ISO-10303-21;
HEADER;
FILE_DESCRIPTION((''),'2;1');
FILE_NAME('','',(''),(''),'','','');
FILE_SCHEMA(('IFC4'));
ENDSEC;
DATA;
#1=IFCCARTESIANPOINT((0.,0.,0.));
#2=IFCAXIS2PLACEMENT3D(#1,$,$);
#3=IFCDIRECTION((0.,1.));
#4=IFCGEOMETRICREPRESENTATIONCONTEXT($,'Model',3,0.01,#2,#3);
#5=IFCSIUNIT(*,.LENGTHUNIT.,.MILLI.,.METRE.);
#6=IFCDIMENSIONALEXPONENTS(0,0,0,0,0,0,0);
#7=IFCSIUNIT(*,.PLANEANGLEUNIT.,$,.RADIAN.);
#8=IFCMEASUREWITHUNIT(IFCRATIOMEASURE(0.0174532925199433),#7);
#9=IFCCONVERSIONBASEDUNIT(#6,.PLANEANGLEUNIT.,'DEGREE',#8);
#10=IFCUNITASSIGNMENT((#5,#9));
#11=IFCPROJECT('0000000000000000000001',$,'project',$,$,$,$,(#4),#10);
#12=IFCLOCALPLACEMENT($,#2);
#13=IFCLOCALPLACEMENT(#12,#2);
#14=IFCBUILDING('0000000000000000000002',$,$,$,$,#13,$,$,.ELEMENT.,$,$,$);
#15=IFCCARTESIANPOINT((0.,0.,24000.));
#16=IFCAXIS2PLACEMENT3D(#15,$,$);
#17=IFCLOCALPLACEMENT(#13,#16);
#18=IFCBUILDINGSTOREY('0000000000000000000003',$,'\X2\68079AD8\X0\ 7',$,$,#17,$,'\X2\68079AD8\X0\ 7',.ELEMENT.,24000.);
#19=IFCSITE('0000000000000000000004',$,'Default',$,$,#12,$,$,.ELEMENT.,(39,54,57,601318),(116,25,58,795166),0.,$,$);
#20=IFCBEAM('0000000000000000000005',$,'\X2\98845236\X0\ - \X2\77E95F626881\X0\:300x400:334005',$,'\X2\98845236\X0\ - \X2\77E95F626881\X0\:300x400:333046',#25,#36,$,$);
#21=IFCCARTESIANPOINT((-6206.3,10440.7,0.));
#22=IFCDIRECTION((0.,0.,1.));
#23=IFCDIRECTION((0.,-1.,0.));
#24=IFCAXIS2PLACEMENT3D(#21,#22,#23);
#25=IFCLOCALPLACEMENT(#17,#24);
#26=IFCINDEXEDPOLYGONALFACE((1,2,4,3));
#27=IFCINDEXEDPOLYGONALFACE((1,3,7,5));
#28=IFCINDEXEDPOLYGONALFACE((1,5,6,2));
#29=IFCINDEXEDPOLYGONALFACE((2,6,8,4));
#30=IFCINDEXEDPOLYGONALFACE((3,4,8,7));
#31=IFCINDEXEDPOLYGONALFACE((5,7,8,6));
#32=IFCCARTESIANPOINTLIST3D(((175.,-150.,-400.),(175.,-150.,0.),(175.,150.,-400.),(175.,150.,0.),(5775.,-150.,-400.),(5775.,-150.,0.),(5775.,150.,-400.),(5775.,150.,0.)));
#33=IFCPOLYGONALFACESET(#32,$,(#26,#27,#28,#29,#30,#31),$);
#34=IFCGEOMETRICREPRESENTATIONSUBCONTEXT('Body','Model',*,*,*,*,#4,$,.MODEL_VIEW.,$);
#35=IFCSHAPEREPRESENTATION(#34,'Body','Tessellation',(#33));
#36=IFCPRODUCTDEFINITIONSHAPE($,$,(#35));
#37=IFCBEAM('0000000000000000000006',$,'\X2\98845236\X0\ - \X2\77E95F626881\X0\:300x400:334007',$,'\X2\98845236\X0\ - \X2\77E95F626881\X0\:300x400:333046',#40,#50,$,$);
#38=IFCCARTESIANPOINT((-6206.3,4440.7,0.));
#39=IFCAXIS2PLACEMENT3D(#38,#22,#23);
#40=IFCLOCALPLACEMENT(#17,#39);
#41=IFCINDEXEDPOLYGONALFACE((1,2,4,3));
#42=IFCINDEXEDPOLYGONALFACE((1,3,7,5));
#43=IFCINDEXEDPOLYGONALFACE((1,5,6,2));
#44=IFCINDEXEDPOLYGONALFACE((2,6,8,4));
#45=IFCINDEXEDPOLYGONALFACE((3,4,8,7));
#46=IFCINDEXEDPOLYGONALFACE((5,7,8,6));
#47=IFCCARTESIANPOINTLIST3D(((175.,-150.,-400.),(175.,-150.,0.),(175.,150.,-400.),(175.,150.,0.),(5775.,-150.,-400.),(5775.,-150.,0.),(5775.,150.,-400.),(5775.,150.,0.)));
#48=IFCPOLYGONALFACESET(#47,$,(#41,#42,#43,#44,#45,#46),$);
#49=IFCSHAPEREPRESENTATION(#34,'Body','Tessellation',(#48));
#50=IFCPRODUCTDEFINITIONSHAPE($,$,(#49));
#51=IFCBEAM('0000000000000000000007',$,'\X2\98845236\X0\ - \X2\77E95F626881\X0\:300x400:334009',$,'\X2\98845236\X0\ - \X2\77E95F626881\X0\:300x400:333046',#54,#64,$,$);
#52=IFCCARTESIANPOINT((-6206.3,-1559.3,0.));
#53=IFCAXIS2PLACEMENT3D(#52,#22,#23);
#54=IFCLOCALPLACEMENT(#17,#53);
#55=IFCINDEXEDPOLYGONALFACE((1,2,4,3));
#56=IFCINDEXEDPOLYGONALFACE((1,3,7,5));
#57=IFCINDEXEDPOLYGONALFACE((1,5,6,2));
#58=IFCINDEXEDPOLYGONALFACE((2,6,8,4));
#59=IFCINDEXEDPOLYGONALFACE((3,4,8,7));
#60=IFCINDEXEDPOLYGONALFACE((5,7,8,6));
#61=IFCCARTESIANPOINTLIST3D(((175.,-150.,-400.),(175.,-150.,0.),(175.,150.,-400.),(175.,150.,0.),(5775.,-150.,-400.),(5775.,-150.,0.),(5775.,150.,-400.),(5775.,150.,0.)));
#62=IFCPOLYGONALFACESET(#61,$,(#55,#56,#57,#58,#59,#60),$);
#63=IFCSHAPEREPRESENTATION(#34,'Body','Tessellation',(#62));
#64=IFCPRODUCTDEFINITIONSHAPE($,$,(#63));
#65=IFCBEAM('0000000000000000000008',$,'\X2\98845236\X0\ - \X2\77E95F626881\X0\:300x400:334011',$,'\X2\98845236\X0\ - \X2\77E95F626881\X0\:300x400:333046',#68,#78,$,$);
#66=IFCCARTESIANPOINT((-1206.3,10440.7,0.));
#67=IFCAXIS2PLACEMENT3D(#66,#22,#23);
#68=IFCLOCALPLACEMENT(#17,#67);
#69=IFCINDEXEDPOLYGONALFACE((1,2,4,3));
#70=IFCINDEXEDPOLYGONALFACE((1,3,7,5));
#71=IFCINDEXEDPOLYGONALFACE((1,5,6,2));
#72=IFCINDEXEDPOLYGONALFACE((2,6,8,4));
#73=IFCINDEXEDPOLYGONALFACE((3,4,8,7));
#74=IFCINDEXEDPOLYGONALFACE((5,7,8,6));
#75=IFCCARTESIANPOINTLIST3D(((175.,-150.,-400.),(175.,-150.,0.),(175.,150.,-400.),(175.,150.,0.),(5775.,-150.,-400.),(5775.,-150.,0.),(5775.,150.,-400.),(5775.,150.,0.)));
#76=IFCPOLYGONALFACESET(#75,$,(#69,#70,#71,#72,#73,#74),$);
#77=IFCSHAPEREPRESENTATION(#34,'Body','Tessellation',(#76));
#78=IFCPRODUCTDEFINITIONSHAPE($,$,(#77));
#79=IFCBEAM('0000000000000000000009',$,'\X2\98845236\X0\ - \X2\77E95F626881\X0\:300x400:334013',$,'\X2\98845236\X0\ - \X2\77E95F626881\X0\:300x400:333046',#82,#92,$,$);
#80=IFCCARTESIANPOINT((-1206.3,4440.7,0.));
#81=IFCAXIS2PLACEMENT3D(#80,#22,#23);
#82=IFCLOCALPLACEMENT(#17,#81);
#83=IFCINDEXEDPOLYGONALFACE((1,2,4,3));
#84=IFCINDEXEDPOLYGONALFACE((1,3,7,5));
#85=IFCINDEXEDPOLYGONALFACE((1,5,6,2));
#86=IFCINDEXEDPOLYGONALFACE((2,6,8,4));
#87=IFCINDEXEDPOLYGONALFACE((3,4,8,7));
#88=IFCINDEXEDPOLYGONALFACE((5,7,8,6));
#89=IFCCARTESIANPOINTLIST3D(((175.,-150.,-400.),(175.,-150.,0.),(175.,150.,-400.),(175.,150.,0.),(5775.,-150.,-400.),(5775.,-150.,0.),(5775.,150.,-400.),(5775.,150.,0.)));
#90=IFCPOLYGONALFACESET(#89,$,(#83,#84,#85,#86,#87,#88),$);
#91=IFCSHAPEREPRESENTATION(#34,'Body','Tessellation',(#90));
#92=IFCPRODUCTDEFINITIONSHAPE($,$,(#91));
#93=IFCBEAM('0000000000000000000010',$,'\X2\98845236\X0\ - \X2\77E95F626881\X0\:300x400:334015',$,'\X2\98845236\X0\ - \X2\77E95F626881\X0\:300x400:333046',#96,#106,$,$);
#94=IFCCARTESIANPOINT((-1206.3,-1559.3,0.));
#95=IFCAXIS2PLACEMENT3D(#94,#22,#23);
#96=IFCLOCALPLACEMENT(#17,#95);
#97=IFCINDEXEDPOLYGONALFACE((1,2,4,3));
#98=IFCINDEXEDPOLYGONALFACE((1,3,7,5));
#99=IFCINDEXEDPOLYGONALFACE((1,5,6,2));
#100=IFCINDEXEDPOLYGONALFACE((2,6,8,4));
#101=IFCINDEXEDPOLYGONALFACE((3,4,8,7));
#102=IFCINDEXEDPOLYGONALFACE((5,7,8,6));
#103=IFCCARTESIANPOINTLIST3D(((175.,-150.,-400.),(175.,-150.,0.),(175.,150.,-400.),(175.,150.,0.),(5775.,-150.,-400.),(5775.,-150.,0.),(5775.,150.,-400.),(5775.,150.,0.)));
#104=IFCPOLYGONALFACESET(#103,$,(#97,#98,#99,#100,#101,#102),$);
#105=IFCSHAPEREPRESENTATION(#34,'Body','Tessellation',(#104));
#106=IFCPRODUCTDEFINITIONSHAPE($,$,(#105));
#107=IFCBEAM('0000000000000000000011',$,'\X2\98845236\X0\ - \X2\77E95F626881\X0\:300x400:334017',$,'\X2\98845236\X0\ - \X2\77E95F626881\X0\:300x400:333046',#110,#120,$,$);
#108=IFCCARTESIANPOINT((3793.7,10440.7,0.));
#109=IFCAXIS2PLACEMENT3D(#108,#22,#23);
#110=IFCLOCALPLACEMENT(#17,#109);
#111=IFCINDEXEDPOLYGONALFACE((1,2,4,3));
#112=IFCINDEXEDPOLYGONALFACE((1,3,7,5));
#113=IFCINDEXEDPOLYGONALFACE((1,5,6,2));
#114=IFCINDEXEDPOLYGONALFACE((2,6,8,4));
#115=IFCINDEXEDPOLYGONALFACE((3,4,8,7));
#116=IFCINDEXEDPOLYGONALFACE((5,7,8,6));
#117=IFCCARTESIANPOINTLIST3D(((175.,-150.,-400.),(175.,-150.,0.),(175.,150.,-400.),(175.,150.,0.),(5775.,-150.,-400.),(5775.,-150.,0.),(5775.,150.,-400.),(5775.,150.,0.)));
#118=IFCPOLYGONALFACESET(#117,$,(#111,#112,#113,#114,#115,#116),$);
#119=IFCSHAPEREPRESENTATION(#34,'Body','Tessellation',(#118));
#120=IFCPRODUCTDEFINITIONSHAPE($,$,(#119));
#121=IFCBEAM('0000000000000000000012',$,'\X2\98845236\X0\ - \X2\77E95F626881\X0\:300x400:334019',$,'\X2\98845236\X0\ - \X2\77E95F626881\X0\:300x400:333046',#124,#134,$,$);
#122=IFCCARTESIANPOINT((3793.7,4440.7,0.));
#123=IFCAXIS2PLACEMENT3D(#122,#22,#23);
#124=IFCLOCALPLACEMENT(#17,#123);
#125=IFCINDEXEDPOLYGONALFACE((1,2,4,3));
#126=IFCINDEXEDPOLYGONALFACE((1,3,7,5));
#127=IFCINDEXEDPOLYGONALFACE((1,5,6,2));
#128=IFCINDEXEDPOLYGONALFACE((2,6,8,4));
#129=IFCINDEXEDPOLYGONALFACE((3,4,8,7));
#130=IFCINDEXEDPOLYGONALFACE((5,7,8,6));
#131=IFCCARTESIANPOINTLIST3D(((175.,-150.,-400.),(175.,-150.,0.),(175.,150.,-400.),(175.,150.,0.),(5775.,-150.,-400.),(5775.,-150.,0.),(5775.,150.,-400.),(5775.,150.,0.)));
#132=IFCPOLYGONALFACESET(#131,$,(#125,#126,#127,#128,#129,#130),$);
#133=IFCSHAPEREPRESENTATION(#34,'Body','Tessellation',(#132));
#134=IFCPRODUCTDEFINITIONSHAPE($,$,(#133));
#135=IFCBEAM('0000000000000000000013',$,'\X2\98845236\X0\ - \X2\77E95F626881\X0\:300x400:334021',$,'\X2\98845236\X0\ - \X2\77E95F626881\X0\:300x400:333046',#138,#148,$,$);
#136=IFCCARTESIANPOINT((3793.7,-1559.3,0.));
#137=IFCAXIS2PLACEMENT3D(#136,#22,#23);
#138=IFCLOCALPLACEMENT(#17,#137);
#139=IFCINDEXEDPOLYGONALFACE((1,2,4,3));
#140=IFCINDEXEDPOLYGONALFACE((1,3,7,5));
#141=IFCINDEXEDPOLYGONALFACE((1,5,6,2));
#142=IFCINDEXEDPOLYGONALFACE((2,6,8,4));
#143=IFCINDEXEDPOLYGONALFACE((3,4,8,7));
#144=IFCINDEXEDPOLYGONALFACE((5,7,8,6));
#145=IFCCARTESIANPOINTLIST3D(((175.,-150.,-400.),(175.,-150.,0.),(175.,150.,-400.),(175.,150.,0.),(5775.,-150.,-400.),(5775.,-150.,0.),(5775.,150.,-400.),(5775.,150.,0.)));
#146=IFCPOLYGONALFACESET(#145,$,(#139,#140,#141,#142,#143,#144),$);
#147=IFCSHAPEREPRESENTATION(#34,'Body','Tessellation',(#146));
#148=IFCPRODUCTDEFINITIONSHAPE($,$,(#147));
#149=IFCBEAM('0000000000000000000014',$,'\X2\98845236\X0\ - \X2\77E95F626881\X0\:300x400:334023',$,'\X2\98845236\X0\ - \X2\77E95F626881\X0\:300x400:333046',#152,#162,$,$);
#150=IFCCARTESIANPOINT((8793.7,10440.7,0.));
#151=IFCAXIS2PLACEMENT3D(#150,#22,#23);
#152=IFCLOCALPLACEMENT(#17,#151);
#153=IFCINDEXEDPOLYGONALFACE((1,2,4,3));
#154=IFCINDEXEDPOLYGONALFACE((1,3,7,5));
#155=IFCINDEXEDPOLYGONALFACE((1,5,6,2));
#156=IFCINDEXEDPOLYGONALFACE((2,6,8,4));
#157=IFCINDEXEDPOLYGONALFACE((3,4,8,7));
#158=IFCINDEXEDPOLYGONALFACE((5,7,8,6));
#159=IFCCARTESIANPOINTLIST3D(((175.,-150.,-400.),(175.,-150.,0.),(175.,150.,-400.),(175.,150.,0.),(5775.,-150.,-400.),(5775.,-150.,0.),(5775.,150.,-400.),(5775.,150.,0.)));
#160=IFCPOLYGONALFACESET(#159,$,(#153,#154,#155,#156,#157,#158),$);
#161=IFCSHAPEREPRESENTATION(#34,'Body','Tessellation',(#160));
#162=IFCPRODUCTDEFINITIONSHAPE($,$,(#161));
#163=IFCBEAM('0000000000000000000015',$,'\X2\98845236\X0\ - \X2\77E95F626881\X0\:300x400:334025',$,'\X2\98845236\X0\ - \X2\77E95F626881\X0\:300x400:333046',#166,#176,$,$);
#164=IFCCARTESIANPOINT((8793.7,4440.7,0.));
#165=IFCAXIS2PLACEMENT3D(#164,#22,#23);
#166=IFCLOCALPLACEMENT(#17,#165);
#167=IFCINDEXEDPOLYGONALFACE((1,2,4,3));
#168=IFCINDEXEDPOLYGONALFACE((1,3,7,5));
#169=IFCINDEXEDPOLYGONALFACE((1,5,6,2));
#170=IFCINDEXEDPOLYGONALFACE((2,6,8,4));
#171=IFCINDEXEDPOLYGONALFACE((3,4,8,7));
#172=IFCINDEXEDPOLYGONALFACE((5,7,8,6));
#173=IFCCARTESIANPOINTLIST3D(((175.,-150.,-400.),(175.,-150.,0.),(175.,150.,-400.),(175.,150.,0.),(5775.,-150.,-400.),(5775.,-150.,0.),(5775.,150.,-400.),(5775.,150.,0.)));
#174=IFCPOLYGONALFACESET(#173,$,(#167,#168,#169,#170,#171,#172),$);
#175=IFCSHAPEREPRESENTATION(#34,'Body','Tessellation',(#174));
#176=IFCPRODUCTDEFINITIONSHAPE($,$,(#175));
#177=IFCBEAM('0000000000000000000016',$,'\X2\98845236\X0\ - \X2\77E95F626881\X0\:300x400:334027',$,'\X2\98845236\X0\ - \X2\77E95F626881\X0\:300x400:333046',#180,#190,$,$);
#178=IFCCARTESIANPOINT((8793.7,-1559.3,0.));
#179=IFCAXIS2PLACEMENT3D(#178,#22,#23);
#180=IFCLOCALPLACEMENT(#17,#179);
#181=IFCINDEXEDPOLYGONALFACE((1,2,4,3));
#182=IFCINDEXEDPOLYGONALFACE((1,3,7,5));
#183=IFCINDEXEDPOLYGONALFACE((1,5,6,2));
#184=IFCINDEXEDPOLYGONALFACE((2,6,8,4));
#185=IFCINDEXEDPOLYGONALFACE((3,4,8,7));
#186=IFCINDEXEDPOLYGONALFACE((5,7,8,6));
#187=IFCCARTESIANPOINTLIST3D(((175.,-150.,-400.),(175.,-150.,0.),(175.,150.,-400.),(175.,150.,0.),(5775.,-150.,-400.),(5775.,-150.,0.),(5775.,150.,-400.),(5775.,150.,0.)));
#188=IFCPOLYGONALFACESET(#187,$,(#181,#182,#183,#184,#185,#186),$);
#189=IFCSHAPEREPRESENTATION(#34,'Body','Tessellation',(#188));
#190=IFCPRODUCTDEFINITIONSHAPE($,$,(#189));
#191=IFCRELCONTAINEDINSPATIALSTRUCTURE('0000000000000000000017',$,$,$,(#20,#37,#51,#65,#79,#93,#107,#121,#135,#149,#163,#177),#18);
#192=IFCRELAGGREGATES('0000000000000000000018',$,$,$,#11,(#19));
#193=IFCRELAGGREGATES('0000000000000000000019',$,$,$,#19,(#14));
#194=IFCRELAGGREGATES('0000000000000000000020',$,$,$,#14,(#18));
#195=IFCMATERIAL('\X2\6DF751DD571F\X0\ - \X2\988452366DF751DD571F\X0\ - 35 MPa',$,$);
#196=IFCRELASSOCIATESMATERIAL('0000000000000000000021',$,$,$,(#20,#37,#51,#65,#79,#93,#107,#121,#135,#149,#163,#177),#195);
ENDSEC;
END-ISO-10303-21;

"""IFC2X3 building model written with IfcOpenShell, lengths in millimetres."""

from ifc_helpers import new_model, entity, si_unit, converted_unit, direction, frame, frame_2d, origin, origin_2d_with_axis, place, context, subcontext, project, spatial, rectangle, extrude, material, element, save


model = new_model("IFC2X3")

# Units and contexts
model_context = context("Model", 3, precision=0.01, world=origin(), true_north=direction((0.0, 1.0)))
body_context = subcontext(model_context, "Body", "Model", "MODEL_VIEW")
ifc_project = project(units=[si_unit("LENGTHUNIT", "METRE", prefix="MILLI"), converted_unit("PLANEANGLEUNIT", "DEGREE", entity("IfcRatioMeasure", 0.0174532925199433), si_unit("PLANEANGLEUNIT", "RADIAN"), dimensions=[0, 0, 0, 0, 0, 0, 0])], contexts=[model_context])

# Site, building, storey
site_placement = place(None, origin())
site = spatial("IfcSite", under=ifc_project, at=site_placement, Name="Default", CompositionType="ELEMENT", RefLatitude=(39, 54, 57, 601318), RefLongitude=(116, 25, 58, 795166), RefElevation=0.0)
building_placement = place(site_placement, origin())
building = spatial("IfcBuilding", under=site, at=building_placement, CompositionType="ELEMENT")
storey_placement = place(building_placement, frame((0.0, 0.0, 24000.0)))
storey = spatial("IfcBuildingStorey", under=building, at=storey_placement, Name="标高 7", LongName="标高 7", CompositionType="ELEMENT", Elevation=24000.0)

# Beams
ifc_material_1 = material(Name="混凝土 - 预制混凝土 - 35 MPa")
for number, where, z_axis, x_axis, name in (
    (1, (-6206.3, 10440.7, 0.0), (0.0, 0.0, 1.0), (0.0, -1.0, 0.0), "预制 - 矩形梁:300x400:334005"),
    (2, (-6206.3, 4440.7, 0.0), (0.0, 0.0, 1.0), (0.0, -1.0, 0.0), "预制 - 矩形梁:300x400:334007"),
    (3, (-6206.3, -1559.3, 0.0), (0.0, 0.0, 1.0), (0.0, -1.0, 0.0), "预制 - 矩形梁:300x400:334009"),
):
    element("IfcBeam", number, at=place(storey_placement, frame(where, z_axis=z_axis, x_axis=x_axis)), inside=storey, material=ifc_material_1, Name=name, ObjectType="预制 - 矩形梁:300x400:333046", context=body_context, shape_type="SweptSolid", body=[
        extrude(rectangle(XDim=400.0, YDim=300.0, at=origin_2d_with_axis()), frame((175.0, 0.0, -200.0), z_axis=(1.0, 0.0, 0.0), x_axis=(0.0, 0.0, -1.0)), (0.0, 0.0, 1.0), 5600.0),
    ])
beam_1_placement = place(storey_placement, frame((-1206.3, 10440.7, 0.0), z_axis=(0.0, 0.0, 1.0), x_axis=(0.0, -1.0, 0.0)))
element("IfcBeam", 4, at=beam_1_placement, inside=storey, material=ifc_material_1, Name="预制 - 矩形梁:300x400:334011", ObjectType="预制 - 矩形梁:300x400:333046", context=body_context, shape_type="SweptSolid", body=[
    extrude(rectangle(XDim=400.0, YDim=300.0, at=frame_2d((0.0, 0.0), x_axis=(1.0, 0.0))), frame((175.0, 0.0, -200.0), z_axis=(1.0, 0.0, 0.0), x_axis=(0.0, 0.0, -1.0)), (0.0, 0.0, 1.0), 5600.0),
])
beam_2_placement = place(storey_placement, frame((-1206.3, 4440.7, 0.0), z_axis=(0.0, 0.0, 1.0), x_axis=(0.0, -1.0, 0.0)))
element("IfcBeam", 5, at=beam_2_placement, inside=storey, material=ifc_material_1, Name="预制 - 矩形梁:300x400:334013", ObjectType="预制 - 矩形梁:300x400:333046", context=body_context, shape_type="SweptSolid", body=[
    extrude(rectangle(XDim=400.0, YDim=300.0, at=frame_2d((0.0, 0.0), x_axis=(1.0, 0.0))), frame((175.0, 0.0, -200.0), z_axis=(1.0, 0.0, 0.0), x_axis=(0.0, 0.0, -1.0)), (0.0, 0.0, 1.0), 5600.0),
])
beam_3_placement = place(storey_placement, frame((-1206.3, -1559.3, 0.0), z_axis=(0.0, 0.0, 1.0), x_axis=(0.0, -1.0, 0.0)))
element("IfcBeam", 6, at=beam_3_placement, inside=storey, material=ifc_material_1, Name="预制 - 矩形梁:300x400:334015", ObjectType="预制 - 矩形梁:300x400:333046", context=body_context, shape_type="SweptSolid", body=[
    extrude(rectangle(XDim=400.0, YDim=300.0, at=frame_2d((0.0, 0.0), x_axis=(1.0, 0.0))), frame((175.0, 0.0, -200.0), z_axis=(1.0, 0.0, 0.0), x_axis=(0.0, 0.0, -1.0)), (0.0, 0.0, 1.0), 5600.0),
])
beam_4_placement = place(storey_placement, frame((3793.7, 10440.7, 0.0), z_axis=(0.0, 0.0, 1.0), x_axis=(0.0, -1.0, 0.0)))
element("IfcBeam", 7, at=beam_4_placement, inside=storey, material=ifc_material_1, Name="预制 - 矩形梁:300x400:334017", ObjectType="预制 - 矩形梁:300x400:333046", context=body_context, shape_type="SweptSolid", body=[
    extrude(rectangle(XDim=400.0, YDim=300.0, at=frame_2d((0.0, 0.0), x_axis=(1.0, 0.0))), frame((175.0, 0.0, -200.0), z_axis=(1.0, 0.0, 0.0), x_axis=(0.0, 0.0, -1.0)), (0.0, 0.0, 1.0), 5600.0),
])
beam_5_placement = place(storey_placement, frame((3793.7, 4440.7, 0.0), z_axis=(0.0, 0.0, 1.0), x_axis=(0.0, -1.0, 0.0)))
element("IfcBeam", 8, at=beam_5_placement, inside=storey, material=ifc_material_1, Name="预制 - 矩形梁:300x400:334019", ObjectType="预制 - 矩形梁:300x400:333046", context=body_context, shape_type="SweptSolid", body=[
    extrude(rectangle(XDim=400.0, YDim=300.0, at=origin_2d_with_axis()), frame((175.0, 0.0, -200.0), z_axis=(1.0, 0.0, 0.0), x_axis=(0.0, 0.0, -1.0)), (0.0, 0.0, 1.0), 5600.0),
])
beam_6_placement = place(storey_placement, frame((3793.7, -1559.3, 0.0), z_axis=(0.0, 0.0, 1.0), x_axis=(0.0, -1.0, 0.0)))
element("IfcBeam", 9, at=beam_6_placement, inside=storey, material=ifc_material_1, Name="预制 - 矩形梁:300x400:334021", ObjectType="预制 - 矩形梁:300x400:333046", context=body_context, shape_type="SweptSolid", body=[
    extrude(rectangle(XDim=400.0, YDim=300.0, at=frame_2d((0.0, 0.0), x_axis=(1.0, 0.0))), frame((175.0, 0.0, -200.0), z_axis=(1.0, 0.0, 0.0), x_axis=(0.0, 0.0, -1.0)), (0.0, 0.0, 1.0), 5600.0),
])
for number, where, z_axis, x_axis, name in (
    (10, (8793.7, 10440.7, 0.0), (0.0, 0.0, 1.0), (0.0, -1.0, 0.0), "预制 - 矩形梁:300x400:334023"),
    (11, (8793.7, 4440.7, 0.0), (0.0, 0.0, 1.0), (0.0, -1.0, 0.0), "预制 - 矩形梁:300x400:334025"),
    (12, (8793.7, -1559.3, 0.0), (0.0, 0.0, 1.0), (0.0, -1.0, 0.0), "预制 - 矩形梁:300x400:334027"),
):
    element("IfcBeam", number, at=place(storey_placement, frame(where, z_axis=z_axis, x_axis=x_axis)), inside=storey, material=ifc_material_1, Name=name, ObjectType="预制 - 矩形梁:300x400:333046", context=body_context, shape_type="SweptSolid", body=[
        extrude(rectangle(XDim=400.0, YDim=300.0, at=origin_2d_with_axis()), frame((175.0, 0.0, -200.0), z_axis=(1.0, 0.0, 0.0), x_axis=(0.0, 0.0, -1.0)), (0.0, 0.0, 1.0), 5600.0),
    ])

save(model, "model.ifc")
